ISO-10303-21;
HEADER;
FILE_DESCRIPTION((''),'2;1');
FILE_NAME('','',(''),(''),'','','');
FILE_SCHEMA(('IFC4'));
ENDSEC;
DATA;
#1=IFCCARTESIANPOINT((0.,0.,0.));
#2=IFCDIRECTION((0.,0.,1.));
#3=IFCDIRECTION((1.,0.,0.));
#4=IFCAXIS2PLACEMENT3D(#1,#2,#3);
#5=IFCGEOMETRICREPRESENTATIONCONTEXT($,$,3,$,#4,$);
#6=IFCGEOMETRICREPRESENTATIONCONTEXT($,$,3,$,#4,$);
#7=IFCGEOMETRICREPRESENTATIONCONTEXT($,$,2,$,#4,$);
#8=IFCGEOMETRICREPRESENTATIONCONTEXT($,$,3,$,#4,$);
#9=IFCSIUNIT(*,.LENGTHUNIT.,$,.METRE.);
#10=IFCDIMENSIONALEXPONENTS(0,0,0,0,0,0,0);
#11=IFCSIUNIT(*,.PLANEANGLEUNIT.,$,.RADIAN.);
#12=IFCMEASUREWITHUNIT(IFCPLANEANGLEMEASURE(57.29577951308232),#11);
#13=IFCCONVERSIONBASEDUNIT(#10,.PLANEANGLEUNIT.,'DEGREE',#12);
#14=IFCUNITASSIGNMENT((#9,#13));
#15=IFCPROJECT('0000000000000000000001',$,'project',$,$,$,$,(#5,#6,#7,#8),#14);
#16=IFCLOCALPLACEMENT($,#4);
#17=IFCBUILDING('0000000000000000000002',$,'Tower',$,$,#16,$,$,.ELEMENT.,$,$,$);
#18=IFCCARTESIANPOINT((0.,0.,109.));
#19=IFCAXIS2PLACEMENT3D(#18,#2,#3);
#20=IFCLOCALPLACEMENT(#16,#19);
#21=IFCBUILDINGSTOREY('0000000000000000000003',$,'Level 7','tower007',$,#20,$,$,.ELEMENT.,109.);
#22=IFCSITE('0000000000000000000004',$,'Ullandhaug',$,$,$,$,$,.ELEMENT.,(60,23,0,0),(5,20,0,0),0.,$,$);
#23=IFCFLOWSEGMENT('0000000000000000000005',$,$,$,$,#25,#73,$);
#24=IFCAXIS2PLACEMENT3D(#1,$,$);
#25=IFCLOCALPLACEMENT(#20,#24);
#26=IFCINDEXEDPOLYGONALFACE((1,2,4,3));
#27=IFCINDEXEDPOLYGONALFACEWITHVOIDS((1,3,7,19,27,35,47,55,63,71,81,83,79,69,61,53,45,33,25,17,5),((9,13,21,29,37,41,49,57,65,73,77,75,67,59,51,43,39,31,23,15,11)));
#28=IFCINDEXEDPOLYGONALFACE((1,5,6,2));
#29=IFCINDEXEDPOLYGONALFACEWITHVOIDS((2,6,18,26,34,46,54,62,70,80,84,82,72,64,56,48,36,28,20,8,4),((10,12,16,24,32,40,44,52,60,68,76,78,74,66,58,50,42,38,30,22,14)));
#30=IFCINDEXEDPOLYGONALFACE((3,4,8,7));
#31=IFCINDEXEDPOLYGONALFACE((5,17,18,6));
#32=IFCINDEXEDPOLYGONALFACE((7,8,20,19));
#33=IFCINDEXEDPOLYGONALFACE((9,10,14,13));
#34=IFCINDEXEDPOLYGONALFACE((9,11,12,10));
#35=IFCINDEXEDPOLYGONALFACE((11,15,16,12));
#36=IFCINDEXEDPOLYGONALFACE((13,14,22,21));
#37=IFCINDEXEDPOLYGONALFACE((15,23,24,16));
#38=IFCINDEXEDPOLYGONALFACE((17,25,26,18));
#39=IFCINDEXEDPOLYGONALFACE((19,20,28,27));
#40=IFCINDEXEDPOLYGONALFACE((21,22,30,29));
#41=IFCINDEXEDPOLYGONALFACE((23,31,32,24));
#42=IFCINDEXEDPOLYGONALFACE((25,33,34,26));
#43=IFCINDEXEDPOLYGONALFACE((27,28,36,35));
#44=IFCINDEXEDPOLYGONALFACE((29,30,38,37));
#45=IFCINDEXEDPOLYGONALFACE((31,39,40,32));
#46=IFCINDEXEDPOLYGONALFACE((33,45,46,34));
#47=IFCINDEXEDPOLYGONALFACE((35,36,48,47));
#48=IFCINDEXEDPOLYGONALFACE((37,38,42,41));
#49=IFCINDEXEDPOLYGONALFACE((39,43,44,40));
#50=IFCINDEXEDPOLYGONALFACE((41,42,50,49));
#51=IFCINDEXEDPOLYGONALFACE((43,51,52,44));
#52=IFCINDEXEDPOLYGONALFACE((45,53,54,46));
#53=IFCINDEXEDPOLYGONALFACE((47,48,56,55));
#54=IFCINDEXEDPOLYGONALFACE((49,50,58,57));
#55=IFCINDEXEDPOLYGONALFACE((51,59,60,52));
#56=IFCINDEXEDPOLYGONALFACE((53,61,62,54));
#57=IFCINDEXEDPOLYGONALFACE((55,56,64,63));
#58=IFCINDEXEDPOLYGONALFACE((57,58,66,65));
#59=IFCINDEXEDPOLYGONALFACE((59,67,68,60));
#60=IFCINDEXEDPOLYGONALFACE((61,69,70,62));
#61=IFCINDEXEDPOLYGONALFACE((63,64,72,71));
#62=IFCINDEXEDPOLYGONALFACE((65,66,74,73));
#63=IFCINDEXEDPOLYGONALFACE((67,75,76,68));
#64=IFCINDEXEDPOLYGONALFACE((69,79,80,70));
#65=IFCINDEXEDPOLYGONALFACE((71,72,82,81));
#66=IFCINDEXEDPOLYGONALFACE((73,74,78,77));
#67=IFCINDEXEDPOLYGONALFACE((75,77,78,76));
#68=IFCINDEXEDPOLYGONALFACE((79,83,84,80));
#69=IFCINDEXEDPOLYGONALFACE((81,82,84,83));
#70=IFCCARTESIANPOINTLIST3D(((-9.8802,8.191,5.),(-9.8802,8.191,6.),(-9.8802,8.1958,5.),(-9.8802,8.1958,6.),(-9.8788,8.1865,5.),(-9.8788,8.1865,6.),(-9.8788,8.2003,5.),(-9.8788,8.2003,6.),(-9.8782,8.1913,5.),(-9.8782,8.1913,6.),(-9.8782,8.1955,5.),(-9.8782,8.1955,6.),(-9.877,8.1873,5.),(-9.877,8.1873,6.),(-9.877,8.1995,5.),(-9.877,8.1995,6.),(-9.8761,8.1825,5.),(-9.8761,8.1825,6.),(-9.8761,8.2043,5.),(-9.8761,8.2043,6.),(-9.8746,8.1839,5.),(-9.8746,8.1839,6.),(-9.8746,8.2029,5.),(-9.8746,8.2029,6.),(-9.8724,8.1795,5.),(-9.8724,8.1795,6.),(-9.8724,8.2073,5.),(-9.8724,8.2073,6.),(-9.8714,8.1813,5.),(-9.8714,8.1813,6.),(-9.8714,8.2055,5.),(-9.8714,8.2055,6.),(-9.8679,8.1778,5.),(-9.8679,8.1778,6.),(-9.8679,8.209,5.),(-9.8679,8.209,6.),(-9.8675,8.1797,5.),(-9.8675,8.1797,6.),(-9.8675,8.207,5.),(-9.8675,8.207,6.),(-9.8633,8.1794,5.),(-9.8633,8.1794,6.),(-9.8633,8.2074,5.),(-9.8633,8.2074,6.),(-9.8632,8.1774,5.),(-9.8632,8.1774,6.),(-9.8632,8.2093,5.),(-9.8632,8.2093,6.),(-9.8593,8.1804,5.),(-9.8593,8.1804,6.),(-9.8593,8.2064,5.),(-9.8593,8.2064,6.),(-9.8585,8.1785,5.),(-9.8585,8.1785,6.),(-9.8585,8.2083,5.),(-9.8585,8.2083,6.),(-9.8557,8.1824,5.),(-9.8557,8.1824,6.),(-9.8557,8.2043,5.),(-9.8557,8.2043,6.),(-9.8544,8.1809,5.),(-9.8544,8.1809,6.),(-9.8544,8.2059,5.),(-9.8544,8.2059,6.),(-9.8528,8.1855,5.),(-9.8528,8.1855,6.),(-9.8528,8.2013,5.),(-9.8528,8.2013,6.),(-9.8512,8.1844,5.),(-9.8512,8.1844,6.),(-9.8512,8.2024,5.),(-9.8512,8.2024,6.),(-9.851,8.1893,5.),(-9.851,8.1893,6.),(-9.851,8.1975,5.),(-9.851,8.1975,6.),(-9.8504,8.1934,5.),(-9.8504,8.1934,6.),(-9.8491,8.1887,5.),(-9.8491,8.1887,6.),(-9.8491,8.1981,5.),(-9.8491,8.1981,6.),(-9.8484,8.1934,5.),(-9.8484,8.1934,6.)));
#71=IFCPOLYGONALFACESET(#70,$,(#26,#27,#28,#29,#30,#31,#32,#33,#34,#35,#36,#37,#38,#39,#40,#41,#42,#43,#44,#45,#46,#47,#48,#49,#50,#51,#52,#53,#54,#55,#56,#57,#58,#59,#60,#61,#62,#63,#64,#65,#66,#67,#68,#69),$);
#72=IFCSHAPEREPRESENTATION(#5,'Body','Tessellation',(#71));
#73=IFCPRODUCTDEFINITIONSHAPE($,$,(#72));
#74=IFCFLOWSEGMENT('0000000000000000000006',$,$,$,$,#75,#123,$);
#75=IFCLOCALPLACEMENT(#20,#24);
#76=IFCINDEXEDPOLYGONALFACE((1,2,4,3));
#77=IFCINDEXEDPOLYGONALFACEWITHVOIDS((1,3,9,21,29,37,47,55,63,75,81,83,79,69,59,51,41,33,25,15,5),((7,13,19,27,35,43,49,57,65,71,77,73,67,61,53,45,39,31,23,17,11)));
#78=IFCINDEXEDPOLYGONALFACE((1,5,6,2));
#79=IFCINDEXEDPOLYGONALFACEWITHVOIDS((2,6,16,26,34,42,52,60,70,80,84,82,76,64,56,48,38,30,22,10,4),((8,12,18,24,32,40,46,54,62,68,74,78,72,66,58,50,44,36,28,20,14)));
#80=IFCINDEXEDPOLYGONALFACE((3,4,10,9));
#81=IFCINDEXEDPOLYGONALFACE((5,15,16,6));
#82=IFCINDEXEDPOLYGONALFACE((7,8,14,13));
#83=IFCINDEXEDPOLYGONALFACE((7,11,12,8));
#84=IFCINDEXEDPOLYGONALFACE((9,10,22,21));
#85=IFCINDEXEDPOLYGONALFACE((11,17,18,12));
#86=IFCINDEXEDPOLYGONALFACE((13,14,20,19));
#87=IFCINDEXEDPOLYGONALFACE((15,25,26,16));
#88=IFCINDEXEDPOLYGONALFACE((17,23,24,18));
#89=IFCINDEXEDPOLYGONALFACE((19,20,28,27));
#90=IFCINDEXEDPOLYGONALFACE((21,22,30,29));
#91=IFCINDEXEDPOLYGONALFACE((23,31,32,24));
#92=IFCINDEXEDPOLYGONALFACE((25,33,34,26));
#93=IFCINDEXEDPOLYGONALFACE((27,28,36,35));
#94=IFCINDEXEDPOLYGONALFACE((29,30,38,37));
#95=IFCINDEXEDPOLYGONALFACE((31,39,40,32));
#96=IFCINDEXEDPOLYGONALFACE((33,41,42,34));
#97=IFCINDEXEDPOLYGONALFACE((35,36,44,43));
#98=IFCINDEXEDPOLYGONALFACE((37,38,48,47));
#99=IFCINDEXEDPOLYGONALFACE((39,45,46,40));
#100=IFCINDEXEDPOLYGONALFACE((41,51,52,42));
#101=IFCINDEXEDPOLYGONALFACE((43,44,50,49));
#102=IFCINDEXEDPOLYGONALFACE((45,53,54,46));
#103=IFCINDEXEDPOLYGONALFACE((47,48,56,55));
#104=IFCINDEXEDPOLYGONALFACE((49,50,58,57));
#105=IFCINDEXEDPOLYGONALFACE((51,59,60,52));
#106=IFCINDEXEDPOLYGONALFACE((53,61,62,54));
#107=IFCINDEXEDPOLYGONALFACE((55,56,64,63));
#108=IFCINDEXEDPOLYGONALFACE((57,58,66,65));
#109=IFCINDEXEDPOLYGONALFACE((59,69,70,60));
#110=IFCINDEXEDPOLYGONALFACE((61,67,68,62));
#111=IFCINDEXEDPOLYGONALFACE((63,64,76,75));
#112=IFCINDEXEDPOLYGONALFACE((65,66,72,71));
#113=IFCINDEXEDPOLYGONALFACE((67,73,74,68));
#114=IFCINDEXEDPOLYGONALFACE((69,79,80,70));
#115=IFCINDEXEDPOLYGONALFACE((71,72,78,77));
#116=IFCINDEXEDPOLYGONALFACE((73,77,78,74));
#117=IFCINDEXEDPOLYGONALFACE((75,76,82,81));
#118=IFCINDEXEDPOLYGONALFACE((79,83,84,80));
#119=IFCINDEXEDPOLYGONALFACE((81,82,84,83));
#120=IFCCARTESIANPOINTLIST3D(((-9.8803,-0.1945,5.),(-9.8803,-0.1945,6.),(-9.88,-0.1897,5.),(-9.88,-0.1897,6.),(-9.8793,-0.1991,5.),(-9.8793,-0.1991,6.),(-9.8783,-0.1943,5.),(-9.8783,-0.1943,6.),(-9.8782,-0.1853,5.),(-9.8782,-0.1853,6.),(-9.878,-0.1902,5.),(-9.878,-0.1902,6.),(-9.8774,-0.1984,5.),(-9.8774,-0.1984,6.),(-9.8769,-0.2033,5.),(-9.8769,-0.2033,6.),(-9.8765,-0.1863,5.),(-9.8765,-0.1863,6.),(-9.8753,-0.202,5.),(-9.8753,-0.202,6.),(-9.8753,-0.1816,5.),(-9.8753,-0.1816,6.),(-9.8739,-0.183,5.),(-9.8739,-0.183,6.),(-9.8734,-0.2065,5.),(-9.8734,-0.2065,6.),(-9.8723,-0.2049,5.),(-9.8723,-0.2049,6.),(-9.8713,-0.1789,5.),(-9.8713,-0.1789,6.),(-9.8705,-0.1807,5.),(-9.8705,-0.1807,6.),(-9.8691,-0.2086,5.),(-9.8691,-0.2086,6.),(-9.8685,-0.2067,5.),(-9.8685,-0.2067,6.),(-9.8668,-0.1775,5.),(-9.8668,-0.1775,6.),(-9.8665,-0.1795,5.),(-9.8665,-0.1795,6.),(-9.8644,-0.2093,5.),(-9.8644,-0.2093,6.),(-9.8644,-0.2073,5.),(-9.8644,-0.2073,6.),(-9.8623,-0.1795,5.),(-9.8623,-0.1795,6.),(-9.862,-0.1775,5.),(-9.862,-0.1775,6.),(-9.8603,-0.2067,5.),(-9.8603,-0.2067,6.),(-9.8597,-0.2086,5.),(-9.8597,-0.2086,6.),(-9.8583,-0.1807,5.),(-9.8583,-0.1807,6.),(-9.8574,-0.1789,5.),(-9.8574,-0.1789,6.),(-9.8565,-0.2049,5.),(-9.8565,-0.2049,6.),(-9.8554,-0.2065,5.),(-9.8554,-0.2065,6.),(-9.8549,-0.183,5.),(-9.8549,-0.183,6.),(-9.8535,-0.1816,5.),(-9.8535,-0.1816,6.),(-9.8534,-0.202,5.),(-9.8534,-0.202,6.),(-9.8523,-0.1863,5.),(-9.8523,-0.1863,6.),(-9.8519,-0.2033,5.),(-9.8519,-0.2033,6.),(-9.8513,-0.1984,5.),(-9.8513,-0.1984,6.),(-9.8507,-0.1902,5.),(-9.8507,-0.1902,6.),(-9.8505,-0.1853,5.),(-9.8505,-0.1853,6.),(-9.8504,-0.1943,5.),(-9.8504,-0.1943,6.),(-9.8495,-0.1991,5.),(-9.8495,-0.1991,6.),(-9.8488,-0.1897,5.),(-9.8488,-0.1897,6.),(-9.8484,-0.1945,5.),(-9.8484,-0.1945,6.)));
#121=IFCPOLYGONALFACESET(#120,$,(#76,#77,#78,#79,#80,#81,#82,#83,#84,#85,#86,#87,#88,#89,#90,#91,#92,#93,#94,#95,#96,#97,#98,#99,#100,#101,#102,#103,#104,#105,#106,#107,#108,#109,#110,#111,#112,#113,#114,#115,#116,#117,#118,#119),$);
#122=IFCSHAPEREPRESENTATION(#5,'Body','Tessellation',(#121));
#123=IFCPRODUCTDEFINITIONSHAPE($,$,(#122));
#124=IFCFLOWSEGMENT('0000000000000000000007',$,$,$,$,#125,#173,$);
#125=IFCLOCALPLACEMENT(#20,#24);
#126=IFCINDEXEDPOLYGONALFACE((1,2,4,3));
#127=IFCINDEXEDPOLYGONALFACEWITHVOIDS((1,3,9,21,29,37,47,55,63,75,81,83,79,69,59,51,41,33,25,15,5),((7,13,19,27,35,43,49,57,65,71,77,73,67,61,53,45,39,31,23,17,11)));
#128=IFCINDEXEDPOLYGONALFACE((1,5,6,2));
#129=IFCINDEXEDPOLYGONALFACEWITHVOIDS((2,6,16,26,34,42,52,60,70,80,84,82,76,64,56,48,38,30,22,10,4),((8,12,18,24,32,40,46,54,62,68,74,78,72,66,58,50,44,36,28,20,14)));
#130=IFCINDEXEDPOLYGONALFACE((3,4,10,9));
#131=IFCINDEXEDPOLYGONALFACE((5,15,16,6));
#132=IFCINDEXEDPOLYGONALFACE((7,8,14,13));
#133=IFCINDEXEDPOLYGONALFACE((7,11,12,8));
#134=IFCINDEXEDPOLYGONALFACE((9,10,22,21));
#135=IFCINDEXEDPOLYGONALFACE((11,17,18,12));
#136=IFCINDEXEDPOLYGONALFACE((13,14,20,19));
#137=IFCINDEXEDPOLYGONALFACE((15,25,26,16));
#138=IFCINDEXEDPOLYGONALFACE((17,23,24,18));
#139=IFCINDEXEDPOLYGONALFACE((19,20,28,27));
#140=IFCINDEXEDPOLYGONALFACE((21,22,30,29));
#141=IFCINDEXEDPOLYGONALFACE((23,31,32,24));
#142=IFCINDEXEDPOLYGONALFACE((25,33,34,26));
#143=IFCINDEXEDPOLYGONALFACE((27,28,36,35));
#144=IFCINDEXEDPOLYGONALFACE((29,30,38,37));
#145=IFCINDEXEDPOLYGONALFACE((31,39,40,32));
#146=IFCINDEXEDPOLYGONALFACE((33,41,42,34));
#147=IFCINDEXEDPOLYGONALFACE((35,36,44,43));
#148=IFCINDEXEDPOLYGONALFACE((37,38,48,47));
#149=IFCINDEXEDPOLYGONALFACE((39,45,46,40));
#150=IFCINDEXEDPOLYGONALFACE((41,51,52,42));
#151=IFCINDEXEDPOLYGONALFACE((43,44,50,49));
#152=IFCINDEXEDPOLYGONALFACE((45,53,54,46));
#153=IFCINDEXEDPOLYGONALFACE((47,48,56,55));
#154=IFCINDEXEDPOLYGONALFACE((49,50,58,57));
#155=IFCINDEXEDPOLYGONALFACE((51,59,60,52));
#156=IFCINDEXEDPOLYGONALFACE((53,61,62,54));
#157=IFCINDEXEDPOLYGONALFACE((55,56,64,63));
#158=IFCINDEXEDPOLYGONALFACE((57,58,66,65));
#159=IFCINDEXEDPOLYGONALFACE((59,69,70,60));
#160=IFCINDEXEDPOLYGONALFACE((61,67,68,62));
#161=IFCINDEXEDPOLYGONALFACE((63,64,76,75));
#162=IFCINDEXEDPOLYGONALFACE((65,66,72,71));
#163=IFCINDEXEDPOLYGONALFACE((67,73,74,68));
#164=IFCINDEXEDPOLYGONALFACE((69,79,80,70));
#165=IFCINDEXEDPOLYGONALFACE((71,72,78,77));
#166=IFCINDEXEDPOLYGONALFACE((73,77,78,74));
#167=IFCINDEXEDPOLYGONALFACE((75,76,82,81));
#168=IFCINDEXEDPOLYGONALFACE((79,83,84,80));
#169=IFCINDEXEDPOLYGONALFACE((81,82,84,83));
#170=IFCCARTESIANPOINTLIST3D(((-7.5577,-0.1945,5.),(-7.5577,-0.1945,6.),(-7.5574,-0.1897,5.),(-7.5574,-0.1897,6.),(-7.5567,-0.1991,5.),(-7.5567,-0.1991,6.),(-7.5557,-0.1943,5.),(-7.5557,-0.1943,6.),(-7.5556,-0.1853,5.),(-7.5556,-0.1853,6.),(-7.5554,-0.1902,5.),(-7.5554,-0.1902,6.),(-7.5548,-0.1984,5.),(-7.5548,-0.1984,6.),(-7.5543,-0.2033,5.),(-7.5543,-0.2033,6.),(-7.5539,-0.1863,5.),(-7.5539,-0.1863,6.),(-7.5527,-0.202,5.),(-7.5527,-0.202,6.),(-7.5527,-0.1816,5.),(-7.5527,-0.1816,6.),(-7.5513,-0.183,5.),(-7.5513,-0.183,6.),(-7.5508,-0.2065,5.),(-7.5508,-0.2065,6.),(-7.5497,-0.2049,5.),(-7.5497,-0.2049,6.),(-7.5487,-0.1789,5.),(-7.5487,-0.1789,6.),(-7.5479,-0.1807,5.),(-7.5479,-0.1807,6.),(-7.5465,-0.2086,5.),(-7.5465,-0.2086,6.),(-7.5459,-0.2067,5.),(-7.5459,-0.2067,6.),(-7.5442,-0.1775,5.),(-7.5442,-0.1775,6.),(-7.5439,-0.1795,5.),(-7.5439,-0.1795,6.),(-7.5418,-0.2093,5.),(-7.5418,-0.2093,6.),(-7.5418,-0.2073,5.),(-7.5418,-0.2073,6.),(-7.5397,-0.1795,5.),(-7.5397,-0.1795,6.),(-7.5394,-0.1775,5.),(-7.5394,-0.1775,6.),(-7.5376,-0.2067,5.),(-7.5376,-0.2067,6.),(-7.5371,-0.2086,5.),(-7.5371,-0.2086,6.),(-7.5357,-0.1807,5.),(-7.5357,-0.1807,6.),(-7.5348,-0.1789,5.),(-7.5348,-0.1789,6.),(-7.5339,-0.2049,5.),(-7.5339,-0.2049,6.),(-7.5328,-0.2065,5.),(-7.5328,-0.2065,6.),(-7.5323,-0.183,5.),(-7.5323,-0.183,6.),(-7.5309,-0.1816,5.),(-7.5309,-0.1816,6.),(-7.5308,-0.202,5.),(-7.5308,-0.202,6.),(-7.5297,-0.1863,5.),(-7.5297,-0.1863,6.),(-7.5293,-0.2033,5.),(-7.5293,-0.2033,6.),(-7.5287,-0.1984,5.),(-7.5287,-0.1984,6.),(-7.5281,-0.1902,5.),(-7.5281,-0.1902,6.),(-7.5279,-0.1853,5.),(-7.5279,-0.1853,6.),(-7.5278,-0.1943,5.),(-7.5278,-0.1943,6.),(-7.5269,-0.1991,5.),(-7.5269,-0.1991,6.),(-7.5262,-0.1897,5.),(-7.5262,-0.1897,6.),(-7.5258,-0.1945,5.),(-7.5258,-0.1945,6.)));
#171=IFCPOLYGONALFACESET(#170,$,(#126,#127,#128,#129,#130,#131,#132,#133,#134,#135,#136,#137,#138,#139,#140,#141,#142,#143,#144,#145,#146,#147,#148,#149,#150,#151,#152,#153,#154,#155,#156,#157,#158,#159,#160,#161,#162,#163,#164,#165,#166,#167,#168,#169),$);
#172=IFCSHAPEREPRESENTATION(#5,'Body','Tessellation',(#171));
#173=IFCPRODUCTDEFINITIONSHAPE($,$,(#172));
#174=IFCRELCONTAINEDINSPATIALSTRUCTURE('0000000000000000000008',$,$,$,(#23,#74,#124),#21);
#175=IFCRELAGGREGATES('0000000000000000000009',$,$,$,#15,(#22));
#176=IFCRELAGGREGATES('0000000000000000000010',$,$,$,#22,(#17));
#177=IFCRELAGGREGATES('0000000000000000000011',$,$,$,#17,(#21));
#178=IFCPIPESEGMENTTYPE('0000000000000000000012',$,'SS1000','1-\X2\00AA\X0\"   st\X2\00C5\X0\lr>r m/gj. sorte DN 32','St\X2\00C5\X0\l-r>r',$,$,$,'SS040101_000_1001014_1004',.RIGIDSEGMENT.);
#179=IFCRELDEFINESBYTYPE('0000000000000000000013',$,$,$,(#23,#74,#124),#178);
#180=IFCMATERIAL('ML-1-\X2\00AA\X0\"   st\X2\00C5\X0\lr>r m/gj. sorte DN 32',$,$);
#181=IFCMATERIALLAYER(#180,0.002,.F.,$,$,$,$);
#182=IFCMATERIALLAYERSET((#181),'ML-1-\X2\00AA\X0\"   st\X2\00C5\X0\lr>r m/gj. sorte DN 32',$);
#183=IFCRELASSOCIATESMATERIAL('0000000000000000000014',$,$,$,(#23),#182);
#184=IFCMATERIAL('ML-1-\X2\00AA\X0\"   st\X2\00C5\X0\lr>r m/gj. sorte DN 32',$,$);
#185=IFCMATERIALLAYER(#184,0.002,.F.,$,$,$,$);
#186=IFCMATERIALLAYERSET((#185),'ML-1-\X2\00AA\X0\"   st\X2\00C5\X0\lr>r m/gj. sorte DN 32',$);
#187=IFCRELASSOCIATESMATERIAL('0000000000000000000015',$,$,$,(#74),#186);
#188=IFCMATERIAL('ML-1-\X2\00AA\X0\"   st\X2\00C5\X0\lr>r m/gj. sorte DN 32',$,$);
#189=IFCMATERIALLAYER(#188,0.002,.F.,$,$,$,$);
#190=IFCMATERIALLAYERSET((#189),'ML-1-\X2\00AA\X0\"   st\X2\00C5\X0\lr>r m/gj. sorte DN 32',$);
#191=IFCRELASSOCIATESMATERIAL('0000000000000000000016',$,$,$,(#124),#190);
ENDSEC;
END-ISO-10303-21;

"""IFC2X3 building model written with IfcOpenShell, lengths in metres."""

from ifc_helpers import new_model, entity, si_unit, converted_unit, frame, origin_with_axes, origin_2d_with_axis, place, context, project, spatial, hollow_circle, extrude, material, layer, layer_set, layer_usage, type_object, element, save


model = new_model("IFC2X3")

# Units and contexts
context_of_model_1 = context(None, 3, world=origin_with_axes())
context_of_model_2 = context(None, 3, world=origin_with_axes())
context_of_model_3 = context(None, 2, world=origin_with_axes())
context_of_model_4 = context(None, 3, world=origin_with_axes())
ifc_project = project(units=[si_unit("LENGTHUNIT", "METRE"), converted_unit("PLANEANGLEUNIT", "DEGREE", entity("IfcPlaneAngleMeasure", 57.29577951308232), si_unit("PLANEANGLEUNIT", "RADIAN"), dimensions=[0, 0, 0, 0, 0, 0, 0])], contexts=[context_of_model_1, context_of_model_2, context_of_model_3, context_of_model_4])

# Site, building, storey
site = spatial("IfcSite", under=ifc_project, Name="Ullandhaug", CompositionType="ELEMENT", RefLatitude=(60, 23, 0, 0), RefLongitude=(5, 20, 0, 0), RefElevation=0.0)
building_placement = place(None, origin_with_axes())
building = spatial("IfcBuilding", under=site, at=building_placement, Name="Tower", CompositionType="ELEMENT")
storey_placement = place(building_placement, frame((0.0, 0.0, 109.0), z_axis=(0.0, 0.0, 1.0), x_axis=(1.0, 0.0, 0.0)))
storey = spatial("IfcBuildingStorey", under=building, at=storey_placement, Name="Level 7", Description="tower007", CompositionType="ELEMENT", Elevation=109.0)

# Flow segments
pipe_segment_type_1 = type_object("IfcPipeSegmentType", Name="SS1000", Description="1-ª\"   stÅlr>r m/gj. sorte DN 32", ApplicableOccurrence="StÅl-r>r", ElementType="SS040101_000_1001014_1004", PredefinedType="RIGIDSEGMENT")
ifc_material_1 = material(Name="ML-1-ª\"   stÅlr>r m/gj. sorte DN 32")
ifc_layer_1 = layer(ifc_material_1, 0.002, ventilated=False)
ifc_layer_set_1 = layer_set([ifc_layer_1], Name="ML-1-ª\"   stÅlr>r m/gj. sorte DN 32")
ifc_layer_usage_1 = layer_usage(ifc_layer_set_1, "AXIS2", "POSITIVE", 0.0)
flow_segment_1_placement = place(storey_placement, frame((-9.8644, 8.1934, 5.0), z_axis=(0.0, 0.0, 1.0), x_axis=(1.0, 0.0, 0.0)))
element("IfcFlowSegment", 1, at=flow_segment_1_placement, inside=storey, type_object=pipe_segment_type_1, material=ifc_layer_usage_1, context=context_of_model_1, shape_type="SweptSolid", body=[
    extrude(hollow_circle(Radius=0.016, WallThickness=0.002, at=origin_2d_with_axis()), origin_with_axes(), (0.0, 0.0, 1.0), 1.0),
])
ifc_material_2 = material(Name="ML-1-ª\"   stÅlr>r m/gj. sorte DN 32")
ifc_layer_2 = layer(ifc_material_2, 0.002, ventilated=False)
ifc_layer_set_2 = layer_set([ifc_layer_2], Name="ML-1-ª\"   stÅlr>r m/gj. sorte DN 32")
ifc_layer_usage_2 = layer_usage(ifc_layer_set_2, "AXIS2", "POSITIVE", 0.0)
flow_segment_2_placement = place(storey_placement, frame((-9.8644, -0.1933, 5.0), z_axis=(0.0, 0.0, 1.0), x_axis=(0.0, -1.0, 0.0)))
element("IfcFlowSegment", 2, at=flow_segment_2_placement, inside=storey, type_object=pipe_segment_type_1, material=ifc_layer_usage_2, context=context_of_model_1, shape_type="SweptSolid", body=[
    extrude(hollow_circle(Radius=0.016, WallThickness=0.002, at=origin_2d_with_axis()), origin_with_axes(), (0.0, 0.0, 1.0), 1.0),
])
ifc_material_3 = material(Name="ML-1-ª\"   stÅlr>r m/gj. sorte DN 32")
ifc_layer_3 = layer(ifc_material_3, 0.002, ventilated=False)
ifc_layer_set_3 = layer_set([ifc_layer_3], Name="ML-1-ª\"   stÅlr>r m/gj. sorte DN 32")
ifc_layer_usage_3 = layer_usage(ifc_layer_set_3, "AXIS2", "POSITIVE", 0.0)
flow_segment_3_placement = place(storey_placement, frame((-7.5418, -0.1933, 5.0), z_axis=(0.0, 0.0, 1.0), x_axis=(0.0, -1.0, 0.0)))
element("IfcFlowSegment", 3, at=flow_segment_3_placement, inside=storey, type_object=pipe_segment_type_1, material=ifc_layer_usage_3, context=context_of_model_1, shape_type="SweptSolid", body=[
    extrude(hollow_circle(Radius=0.016, WallThickness=0.002, at=origin_2d_with_axis()), origin_with_axes(), (0.0, 0.0, 1.0), 1.0),
])

save(model, "model.ifc")
